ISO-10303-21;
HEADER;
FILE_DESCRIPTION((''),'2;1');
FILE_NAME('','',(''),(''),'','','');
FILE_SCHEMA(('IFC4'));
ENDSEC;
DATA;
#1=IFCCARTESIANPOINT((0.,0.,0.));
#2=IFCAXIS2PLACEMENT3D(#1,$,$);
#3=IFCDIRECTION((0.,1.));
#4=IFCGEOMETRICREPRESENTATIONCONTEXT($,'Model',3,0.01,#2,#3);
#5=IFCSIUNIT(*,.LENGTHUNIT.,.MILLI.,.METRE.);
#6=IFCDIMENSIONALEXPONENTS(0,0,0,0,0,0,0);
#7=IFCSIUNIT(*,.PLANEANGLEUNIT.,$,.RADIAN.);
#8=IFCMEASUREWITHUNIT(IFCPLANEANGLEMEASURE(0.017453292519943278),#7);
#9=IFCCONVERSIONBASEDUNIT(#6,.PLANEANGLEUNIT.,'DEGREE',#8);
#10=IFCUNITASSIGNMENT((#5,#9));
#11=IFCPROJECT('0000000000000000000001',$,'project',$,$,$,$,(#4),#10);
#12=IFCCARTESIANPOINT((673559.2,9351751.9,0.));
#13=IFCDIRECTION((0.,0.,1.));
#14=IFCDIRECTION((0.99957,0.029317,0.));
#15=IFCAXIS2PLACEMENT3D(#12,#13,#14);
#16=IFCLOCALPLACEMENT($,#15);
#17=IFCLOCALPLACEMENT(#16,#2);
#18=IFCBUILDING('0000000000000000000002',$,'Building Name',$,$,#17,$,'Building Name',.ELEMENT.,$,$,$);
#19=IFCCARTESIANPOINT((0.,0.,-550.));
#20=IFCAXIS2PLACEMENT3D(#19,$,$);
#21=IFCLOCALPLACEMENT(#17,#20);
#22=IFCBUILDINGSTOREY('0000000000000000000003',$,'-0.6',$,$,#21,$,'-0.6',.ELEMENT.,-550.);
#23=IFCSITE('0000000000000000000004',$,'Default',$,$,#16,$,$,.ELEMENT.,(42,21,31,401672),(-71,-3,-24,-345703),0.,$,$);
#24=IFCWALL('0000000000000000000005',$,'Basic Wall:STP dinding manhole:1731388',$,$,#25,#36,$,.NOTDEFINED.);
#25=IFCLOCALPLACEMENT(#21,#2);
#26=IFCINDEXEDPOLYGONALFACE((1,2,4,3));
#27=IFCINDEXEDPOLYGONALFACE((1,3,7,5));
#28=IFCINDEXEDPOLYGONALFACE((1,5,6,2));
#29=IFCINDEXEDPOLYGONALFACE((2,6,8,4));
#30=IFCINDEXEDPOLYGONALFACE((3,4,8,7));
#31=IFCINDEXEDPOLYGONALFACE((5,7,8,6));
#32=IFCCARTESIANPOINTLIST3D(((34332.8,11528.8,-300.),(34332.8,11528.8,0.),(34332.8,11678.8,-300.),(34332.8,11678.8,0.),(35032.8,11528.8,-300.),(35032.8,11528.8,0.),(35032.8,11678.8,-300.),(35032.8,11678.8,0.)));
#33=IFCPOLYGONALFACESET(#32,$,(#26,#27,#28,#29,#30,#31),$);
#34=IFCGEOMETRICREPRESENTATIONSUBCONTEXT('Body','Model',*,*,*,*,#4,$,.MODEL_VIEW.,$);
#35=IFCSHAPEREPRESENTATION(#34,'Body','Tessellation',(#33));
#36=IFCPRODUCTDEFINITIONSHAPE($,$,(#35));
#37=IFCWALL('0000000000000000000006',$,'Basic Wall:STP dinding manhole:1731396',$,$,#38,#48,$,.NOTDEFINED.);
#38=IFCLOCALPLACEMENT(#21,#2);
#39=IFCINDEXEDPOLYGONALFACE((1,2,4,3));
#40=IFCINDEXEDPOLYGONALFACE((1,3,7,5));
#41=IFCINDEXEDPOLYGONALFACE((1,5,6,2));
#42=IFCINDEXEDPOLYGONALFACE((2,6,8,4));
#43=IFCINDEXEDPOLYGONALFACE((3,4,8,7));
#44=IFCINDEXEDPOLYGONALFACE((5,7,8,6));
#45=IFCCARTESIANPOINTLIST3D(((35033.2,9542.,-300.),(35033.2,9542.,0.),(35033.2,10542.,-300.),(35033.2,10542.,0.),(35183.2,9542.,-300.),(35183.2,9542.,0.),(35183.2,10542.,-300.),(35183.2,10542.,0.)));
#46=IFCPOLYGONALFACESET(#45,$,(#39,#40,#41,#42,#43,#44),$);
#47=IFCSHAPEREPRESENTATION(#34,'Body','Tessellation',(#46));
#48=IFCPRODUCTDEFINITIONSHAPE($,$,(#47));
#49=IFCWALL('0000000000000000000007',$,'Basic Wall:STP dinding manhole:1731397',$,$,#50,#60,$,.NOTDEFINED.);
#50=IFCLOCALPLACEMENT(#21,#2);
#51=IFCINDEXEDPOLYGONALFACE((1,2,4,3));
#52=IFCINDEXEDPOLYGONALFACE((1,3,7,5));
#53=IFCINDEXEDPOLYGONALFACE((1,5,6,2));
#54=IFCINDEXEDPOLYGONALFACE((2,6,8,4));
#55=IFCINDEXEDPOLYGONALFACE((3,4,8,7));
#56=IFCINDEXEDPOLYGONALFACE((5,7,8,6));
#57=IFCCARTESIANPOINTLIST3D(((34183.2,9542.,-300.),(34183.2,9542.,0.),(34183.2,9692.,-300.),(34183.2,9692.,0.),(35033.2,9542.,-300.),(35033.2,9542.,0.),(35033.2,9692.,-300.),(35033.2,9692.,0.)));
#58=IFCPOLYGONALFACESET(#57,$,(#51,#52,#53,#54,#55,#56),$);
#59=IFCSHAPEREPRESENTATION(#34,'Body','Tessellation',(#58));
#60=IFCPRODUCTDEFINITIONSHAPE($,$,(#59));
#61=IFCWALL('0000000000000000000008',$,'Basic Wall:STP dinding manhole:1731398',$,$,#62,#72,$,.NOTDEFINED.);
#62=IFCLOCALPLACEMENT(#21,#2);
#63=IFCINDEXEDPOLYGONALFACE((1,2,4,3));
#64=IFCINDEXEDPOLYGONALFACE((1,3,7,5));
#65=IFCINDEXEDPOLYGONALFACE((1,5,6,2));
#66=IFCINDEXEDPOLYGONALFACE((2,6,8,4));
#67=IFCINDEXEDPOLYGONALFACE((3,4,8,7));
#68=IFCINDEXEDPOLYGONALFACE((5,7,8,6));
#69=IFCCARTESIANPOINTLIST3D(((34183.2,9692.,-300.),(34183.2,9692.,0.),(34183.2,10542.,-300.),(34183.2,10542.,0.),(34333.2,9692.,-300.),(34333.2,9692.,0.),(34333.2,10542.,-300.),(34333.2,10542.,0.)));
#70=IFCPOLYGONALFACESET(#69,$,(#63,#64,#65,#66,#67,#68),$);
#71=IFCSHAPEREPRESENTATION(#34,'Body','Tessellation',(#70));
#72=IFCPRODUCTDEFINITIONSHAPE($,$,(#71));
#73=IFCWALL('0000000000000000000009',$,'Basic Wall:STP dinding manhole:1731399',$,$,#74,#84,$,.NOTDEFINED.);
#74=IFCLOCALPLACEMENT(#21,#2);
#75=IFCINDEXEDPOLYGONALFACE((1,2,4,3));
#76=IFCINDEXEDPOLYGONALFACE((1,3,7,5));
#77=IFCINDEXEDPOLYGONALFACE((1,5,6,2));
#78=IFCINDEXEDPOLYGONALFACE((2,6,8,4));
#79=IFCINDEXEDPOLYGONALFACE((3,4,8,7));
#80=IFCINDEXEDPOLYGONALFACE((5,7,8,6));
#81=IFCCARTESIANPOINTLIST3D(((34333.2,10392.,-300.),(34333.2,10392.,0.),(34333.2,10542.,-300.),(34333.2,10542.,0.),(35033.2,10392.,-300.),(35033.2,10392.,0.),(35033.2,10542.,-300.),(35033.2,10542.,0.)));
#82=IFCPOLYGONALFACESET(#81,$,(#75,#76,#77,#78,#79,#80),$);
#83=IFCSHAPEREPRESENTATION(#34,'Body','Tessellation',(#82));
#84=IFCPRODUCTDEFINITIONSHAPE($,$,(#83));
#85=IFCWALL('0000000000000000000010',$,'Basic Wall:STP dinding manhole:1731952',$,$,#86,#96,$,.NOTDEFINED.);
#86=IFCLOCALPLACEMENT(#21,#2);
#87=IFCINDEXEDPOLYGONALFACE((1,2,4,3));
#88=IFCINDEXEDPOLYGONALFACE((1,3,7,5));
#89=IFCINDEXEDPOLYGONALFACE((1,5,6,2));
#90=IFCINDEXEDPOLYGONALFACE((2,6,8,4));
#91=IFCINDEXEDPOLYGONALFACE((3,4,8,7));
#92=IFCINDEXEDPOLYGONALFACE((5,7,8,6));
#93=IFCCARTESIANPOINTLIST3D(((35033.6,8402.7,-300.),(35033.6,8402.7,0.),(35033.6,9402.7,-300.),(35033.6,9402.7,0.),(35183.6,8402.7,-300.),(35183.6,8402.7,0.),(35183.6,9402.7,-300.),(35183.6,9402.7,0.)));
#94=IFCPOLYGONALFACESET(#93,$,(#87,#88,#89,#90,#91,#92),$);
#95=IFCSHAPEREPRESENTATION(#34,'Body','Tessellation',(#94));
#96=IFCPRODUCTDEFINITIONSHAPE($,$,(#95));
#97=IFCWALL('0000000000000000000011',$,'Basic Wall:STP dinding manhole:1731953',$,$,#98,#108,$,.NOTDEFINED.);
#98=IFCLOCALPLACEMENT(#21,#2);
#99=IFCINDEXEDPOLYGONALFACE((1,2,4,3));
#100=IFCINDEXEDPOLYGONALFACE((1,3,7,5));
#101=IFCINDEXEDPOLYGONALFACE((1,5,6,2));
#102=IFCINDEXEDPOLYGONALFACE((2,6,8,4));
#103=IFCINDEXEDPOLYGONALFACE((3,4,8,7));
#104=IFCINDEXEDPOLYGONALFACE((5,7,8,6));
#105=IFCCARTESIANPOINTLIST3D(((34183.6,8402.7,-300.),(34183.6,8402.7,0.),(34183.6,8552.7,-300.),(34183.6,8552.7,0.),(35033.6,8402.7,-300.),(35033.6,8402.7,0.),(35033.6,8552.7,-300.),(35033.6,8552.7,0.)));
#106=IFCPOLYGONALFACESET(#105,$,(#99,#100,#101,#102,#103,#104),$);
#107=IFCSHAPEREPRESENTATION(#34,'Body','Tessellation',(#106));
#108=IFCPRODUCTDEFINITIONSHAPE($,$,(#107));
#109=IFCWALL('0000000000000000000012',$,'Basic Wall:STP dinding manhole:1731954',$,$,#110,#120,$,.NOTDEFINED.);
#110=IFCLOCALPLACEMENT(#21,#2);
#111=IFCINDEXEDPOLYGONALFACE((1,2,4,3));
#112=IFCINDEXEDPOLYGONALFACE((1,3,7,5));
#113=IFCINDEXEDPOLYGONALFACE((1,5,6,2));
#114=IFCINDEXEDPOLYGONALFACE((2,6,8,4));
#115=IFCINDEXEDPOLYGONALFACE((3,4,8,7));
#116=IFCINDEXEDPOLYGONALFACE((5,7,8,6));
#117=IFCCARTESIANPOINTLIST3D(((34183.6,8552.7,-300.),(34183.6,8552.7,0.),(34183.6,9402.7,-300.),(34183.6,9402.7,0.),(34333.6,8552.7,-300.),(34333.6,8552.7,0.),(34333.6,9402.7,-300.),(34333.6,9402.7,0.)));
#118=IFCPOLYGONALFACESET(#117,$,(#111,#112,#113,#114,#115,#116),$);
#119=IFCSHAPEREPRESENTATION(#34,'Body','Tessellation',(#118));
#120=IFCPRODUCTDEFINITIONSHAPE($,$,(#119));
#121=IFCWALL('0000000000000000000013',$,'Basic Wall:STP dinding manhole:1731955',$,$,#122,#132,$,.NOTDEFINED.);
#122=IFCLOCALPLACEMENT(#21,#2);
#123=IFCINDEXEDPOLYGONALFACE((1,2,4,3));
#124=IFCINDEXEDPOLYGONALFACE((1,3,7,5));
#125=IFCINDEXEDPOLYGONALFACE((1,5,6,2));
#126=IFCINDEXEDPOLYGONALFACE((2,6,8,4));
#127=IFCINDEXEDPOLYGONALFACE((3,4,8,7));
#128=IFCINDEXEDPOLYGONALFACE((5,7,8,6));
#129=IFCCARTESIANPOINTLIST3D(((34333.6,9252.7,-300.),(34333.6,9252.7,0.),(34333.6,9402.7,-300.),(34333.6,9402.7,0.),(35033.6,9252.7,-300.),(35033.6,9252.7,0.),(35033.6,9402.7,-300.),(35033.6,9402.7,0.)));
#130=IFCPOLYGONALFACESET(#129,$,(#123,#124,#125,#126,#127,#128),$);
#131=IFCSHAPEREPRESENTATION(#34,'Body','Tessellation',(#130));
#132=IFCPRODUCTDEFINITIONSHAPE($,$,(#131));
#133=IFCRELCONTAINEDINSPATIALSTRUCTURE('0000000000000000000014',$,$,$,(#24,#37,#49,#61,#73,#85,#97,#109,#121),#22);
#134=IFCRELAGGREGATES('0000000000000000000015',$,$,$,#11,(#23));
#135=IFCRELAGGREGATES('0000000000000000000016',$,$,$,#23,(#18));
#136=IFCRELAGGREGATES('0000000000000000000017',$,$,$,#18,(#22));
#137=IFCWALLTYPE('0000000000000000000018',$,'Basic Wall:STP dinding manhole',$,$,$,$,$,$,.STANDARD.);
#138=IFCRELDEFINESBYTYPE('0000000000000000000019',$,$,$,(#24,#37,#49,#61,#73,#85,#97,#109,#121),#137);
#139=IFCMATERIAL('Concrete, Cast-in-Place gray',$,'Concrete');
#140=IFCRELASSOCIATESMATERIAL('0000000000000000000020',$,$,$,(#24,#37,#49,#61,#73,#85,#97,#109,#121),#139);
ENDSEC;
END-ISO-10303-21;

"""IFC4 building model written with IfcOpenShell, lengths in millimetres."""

from ifc_helpers import new_model, entity, si_unit, converted_unit, direction, frame, origin, place, context, subcontext, project, spatial, indexed_curve, outline, extrude, material, type_object, element, save


model = new_model("IFC4")

# Units and contexts
model_context = context("Model", 3, precision=0.01, world=origin(), true_north=direction((0.0, 1.0)))
body_context = subcontext(model_context, "Body", "Model", "MODEL_VIEW")
ifc_project = project(units=[si_unit("LENGTHUNIT", "METRE", prefix="MILLI"), converted_unit("PLANEANGLEUNIT", "DEGREE", entity("IfcPlaneAngleMeasure", 0.017453292519943278), si_unit("PLANEANGLEUNIT", "RADIAN"), dimensions=[0, 0, 0, 0, 0, 0, 0])], contexts=[model_context])

# Site, building, storey
site_placement = place(None, frame((673559.2, 9351751.9, 0.0), z_axis=(0.0, 0.0, 1.0), x_axis=(0.99957, 0.029317, 0.0)))
site = spatial("IfcSite", under=ifc_project, at=site_placement, Name="Default", CompositionType="ELEMENT", RefLatitude=(42, 21, 31, 401672), RefLongitude=(-71, -3, -24, -345703), RefElevation=0.0)
building_placement = place(site_placement, origin())
building = spatial("IfcBuilding", under=site, at=building_placement, Name="Building Name", LongName="Building Name", CompositionType="ELEMENT")
storey_placement = place(building_placement, frame((0.0, 0.0, -550.0)))
storey = spatial("IfcBuildingStorey", under=building, at=storey_placement, Name="-0.6", LongName="-0.6", CompositionType="ELEMENT", Elevation=-550.0)

# Walls
ifc_material_1 = material(Name="Concrete, Cast-in-Place gray", Category="Concrete")
wall_type_1 = type_object("IfcWallType", Name="Basic Wall:STP dinding manhole", PredefinedType="STANDARD")
wall_1_placement = place(storey_placement, frame((34332.8, 11603.8, -300.0)))
element("IfcWall", 1, at=wall_1_placement, inside=storey, type_object=wall_type_1, material=ifc_material_1, Name="Basic Wall:STP dinding manhole:1731388", PredefinedType="NOTDEFINED", context=body_context, shape_type="SweptSolid", body=[
    extrude(outline(indexed_curve([(700.0, 75.0), (0.0, 75.0), (0.0, -75.0), (700.0, -75.0), (700.0, 75.0)], self_intersect=False)), origin(), (0.0, 0.0, 1.0), 300.0),
])
wall_2_placement = place(storey_placement, frame((35108.2, 10542.0, -300.0), z_axis=(0.0, 0.0, 1.0), x_axis=(0.0, -1.0, 0.0)))
element("IfcWall", 2, at=wall_2_placement, inside=storey, type_object=wall_type_1, material=ifc_material_1, Name="Basic Wall:STP dinding manhole:1731396", PredefinedType="NOTDEFINED", context=body_context, shape_type="SweptSolid", body=[
    extrude(outline(indexed_curve([(1000.0, 75.0), (0.0, 75.0), (0.0, -75.0), (1000.0, -75.0), (1000.0, 75.0)], self_intersect=False)), origin(), (0.0, 0.0, 1.0), 300.0),
])
wall_3_placement = place(storey_placement, frame((35033.2, 9617.0, -300.0), z_axis=(0.0, 0.0, 1.0), x_axis=(-1.0, 0.0, 0.0)))
element("IfcWall", 3, at=wall_3_placement, inside=storey, type_object=wall_type_1, material=ifc_material_1, Name="Basic Wall:STP dinding manhole:1731397", PredefinedType="NOTDEFINED", context=body_context, shape_type="SweptSolid", body=[
    extrude(outline(indexed_curve([(850.0, 75.0), (0.0, 75.0), (0.0, -75.0), (850.0, -75.0), (850.0, 75.0)], self_intersect=False)), origin(), (0.0, 0.0, 1.0), 300.0),
])
wall_4_placement = place(storey_placement, frame((34258.2, 9692.0, -300.0), z_axis=(0.0, 0.0, 1.0), x_axis=(0.0, 1.0, 0.0)))
element("IfcWall", 4, at=wall_4_placement, inside=storey, type_object=wall_type_1, material=ifc_material_1, Name="Basic Wall:STP dinding manhole:1731398", PredefinedType="NOTDEFINED", context=body_context, shape_type="SweptSolid", body=[
    extrude(outline(indexed_curve([(850.0, 75.0), (0.0, 75.0), (0.0, -75.0), (850.0, -75.0), (850.0, 75.0)], self_intersect=False)), origin(), (0.0, 0.0, 1.0), 300.0),
])
wall_5_placement = place(storey_placement, frame((34333.2, 10467.0, -300.0)))
element("IfcWall", 5, at=wall_5_placement, inside=storey, type_object=wall_type_1, material=ifc_material_1, Name="Basic Wall:STP dinding manhole:1731399", PredefinedType="NOTDEFINED", context=body_context, shape_type="SweptSolid", body=[
    extrude(outline(indexed_curve([(700.0, 75.0), (0.0, 75.0), (0.0, -75.0), (700.0, -75.0), (700.0, 75.0)], self_intersect=False)), origin(), (0.0, 0.0, 1.0), 300.0),
])
wall_6_placement = place(storey_placement, frame((35108.6, 9402.7, -300.0), z_axis=(0.0, 0.0, 1.0), x_axis=(0.0, -1.0, 0.0)))
element("IfcWall", 6, at=wall_6_placement, inside=storey, type_object=wall_type_1, material=ifc_material_1, Name="Basic Wall:STP dinding manhole:1731952", PredefinedType="NOTDEFINED", context=body_context, shape_type="SweptSolid", body=[
    extrude(outline(indexed_curve([(1000.0, 75.0), (0.0, 75.0), (0.0, -75.0), (1000.0, -75.0), (1000.0, 75.0)], self_intersect=False)), origin(), (0.0, 0.0, 1.0), 300.0),
])
wall_7_placement = place(storey_placement, frame((35033.6, 8477.7, -300.0), z_axis=(0.0, 0.0, 1.0), x_axis=(-1.0, 0.0, 0.0)))
element("IfcWall", 7, at=wall_7_placement, inside=storey, type_object=wall_type_1, material=ifc_material_1, Name="Basic Wall:STP dinding manhole:1731953", PredefinedType="NOTDEFINED", context=body_context, shape_type="SweptSolid", body=[
    extrude(outline(indexed_curve([(850.0, 75.0), (0.0, 75.0), (0.0, -75.0), (850.0, -75.0), (850.0, 75.0)], self_intersect=False)), origin(), (0.0, 0.0, 1.0), 300.0),
])
wall_8_placement = place(storey_placement, frame((34258.6, 8552.7, -300.0), z_axis=(0.0, 0.0, 1.0), x_axis=(0.0, 1.0, 0.0)))
element("IfcWall", 8, at=wall_8_placement, inside=storey, type_object=wall_type_1, material=ifc_material_1, Name="Basic Wall:STP dinding manhole:1731954", PredefinedType="NOTDEFINED", context=body_context, shape_type="SweptSolid", body=[
    extrude(outline(indexed_curve([(850.0, 75.0), (0.0, 75.0), (0.0, -75.0), (850.0, -75.0), (850.0, 75.0)], self_intersect=False)), origin(), (0.0, 0.0, 1.0), 300.0),
])
wall_9_placement = place(storey_placement, frame((34333.6, 9327.7, -300.0)))
element("IfcWall", 9, at=wall_9_placement, inside=storey, type_object=wall_type_1, material=ifc_material_1, Name="Basic Wall:STP dinding manhole:1731955", PredefinedType="NOTDEFINED", context=body_context, shape_type="SweptSolid", body=[
    extrude(outline(indexed_curve([(700.0, 75.0), (0.0, 75.0), (0.0, -75.0), (700.0, -75.0), (700.0, 75.0)], self_intersect=False)), origin(), (0.0, 0.0, 1.0), 300.0),
])

save(model, "model.ifc")
